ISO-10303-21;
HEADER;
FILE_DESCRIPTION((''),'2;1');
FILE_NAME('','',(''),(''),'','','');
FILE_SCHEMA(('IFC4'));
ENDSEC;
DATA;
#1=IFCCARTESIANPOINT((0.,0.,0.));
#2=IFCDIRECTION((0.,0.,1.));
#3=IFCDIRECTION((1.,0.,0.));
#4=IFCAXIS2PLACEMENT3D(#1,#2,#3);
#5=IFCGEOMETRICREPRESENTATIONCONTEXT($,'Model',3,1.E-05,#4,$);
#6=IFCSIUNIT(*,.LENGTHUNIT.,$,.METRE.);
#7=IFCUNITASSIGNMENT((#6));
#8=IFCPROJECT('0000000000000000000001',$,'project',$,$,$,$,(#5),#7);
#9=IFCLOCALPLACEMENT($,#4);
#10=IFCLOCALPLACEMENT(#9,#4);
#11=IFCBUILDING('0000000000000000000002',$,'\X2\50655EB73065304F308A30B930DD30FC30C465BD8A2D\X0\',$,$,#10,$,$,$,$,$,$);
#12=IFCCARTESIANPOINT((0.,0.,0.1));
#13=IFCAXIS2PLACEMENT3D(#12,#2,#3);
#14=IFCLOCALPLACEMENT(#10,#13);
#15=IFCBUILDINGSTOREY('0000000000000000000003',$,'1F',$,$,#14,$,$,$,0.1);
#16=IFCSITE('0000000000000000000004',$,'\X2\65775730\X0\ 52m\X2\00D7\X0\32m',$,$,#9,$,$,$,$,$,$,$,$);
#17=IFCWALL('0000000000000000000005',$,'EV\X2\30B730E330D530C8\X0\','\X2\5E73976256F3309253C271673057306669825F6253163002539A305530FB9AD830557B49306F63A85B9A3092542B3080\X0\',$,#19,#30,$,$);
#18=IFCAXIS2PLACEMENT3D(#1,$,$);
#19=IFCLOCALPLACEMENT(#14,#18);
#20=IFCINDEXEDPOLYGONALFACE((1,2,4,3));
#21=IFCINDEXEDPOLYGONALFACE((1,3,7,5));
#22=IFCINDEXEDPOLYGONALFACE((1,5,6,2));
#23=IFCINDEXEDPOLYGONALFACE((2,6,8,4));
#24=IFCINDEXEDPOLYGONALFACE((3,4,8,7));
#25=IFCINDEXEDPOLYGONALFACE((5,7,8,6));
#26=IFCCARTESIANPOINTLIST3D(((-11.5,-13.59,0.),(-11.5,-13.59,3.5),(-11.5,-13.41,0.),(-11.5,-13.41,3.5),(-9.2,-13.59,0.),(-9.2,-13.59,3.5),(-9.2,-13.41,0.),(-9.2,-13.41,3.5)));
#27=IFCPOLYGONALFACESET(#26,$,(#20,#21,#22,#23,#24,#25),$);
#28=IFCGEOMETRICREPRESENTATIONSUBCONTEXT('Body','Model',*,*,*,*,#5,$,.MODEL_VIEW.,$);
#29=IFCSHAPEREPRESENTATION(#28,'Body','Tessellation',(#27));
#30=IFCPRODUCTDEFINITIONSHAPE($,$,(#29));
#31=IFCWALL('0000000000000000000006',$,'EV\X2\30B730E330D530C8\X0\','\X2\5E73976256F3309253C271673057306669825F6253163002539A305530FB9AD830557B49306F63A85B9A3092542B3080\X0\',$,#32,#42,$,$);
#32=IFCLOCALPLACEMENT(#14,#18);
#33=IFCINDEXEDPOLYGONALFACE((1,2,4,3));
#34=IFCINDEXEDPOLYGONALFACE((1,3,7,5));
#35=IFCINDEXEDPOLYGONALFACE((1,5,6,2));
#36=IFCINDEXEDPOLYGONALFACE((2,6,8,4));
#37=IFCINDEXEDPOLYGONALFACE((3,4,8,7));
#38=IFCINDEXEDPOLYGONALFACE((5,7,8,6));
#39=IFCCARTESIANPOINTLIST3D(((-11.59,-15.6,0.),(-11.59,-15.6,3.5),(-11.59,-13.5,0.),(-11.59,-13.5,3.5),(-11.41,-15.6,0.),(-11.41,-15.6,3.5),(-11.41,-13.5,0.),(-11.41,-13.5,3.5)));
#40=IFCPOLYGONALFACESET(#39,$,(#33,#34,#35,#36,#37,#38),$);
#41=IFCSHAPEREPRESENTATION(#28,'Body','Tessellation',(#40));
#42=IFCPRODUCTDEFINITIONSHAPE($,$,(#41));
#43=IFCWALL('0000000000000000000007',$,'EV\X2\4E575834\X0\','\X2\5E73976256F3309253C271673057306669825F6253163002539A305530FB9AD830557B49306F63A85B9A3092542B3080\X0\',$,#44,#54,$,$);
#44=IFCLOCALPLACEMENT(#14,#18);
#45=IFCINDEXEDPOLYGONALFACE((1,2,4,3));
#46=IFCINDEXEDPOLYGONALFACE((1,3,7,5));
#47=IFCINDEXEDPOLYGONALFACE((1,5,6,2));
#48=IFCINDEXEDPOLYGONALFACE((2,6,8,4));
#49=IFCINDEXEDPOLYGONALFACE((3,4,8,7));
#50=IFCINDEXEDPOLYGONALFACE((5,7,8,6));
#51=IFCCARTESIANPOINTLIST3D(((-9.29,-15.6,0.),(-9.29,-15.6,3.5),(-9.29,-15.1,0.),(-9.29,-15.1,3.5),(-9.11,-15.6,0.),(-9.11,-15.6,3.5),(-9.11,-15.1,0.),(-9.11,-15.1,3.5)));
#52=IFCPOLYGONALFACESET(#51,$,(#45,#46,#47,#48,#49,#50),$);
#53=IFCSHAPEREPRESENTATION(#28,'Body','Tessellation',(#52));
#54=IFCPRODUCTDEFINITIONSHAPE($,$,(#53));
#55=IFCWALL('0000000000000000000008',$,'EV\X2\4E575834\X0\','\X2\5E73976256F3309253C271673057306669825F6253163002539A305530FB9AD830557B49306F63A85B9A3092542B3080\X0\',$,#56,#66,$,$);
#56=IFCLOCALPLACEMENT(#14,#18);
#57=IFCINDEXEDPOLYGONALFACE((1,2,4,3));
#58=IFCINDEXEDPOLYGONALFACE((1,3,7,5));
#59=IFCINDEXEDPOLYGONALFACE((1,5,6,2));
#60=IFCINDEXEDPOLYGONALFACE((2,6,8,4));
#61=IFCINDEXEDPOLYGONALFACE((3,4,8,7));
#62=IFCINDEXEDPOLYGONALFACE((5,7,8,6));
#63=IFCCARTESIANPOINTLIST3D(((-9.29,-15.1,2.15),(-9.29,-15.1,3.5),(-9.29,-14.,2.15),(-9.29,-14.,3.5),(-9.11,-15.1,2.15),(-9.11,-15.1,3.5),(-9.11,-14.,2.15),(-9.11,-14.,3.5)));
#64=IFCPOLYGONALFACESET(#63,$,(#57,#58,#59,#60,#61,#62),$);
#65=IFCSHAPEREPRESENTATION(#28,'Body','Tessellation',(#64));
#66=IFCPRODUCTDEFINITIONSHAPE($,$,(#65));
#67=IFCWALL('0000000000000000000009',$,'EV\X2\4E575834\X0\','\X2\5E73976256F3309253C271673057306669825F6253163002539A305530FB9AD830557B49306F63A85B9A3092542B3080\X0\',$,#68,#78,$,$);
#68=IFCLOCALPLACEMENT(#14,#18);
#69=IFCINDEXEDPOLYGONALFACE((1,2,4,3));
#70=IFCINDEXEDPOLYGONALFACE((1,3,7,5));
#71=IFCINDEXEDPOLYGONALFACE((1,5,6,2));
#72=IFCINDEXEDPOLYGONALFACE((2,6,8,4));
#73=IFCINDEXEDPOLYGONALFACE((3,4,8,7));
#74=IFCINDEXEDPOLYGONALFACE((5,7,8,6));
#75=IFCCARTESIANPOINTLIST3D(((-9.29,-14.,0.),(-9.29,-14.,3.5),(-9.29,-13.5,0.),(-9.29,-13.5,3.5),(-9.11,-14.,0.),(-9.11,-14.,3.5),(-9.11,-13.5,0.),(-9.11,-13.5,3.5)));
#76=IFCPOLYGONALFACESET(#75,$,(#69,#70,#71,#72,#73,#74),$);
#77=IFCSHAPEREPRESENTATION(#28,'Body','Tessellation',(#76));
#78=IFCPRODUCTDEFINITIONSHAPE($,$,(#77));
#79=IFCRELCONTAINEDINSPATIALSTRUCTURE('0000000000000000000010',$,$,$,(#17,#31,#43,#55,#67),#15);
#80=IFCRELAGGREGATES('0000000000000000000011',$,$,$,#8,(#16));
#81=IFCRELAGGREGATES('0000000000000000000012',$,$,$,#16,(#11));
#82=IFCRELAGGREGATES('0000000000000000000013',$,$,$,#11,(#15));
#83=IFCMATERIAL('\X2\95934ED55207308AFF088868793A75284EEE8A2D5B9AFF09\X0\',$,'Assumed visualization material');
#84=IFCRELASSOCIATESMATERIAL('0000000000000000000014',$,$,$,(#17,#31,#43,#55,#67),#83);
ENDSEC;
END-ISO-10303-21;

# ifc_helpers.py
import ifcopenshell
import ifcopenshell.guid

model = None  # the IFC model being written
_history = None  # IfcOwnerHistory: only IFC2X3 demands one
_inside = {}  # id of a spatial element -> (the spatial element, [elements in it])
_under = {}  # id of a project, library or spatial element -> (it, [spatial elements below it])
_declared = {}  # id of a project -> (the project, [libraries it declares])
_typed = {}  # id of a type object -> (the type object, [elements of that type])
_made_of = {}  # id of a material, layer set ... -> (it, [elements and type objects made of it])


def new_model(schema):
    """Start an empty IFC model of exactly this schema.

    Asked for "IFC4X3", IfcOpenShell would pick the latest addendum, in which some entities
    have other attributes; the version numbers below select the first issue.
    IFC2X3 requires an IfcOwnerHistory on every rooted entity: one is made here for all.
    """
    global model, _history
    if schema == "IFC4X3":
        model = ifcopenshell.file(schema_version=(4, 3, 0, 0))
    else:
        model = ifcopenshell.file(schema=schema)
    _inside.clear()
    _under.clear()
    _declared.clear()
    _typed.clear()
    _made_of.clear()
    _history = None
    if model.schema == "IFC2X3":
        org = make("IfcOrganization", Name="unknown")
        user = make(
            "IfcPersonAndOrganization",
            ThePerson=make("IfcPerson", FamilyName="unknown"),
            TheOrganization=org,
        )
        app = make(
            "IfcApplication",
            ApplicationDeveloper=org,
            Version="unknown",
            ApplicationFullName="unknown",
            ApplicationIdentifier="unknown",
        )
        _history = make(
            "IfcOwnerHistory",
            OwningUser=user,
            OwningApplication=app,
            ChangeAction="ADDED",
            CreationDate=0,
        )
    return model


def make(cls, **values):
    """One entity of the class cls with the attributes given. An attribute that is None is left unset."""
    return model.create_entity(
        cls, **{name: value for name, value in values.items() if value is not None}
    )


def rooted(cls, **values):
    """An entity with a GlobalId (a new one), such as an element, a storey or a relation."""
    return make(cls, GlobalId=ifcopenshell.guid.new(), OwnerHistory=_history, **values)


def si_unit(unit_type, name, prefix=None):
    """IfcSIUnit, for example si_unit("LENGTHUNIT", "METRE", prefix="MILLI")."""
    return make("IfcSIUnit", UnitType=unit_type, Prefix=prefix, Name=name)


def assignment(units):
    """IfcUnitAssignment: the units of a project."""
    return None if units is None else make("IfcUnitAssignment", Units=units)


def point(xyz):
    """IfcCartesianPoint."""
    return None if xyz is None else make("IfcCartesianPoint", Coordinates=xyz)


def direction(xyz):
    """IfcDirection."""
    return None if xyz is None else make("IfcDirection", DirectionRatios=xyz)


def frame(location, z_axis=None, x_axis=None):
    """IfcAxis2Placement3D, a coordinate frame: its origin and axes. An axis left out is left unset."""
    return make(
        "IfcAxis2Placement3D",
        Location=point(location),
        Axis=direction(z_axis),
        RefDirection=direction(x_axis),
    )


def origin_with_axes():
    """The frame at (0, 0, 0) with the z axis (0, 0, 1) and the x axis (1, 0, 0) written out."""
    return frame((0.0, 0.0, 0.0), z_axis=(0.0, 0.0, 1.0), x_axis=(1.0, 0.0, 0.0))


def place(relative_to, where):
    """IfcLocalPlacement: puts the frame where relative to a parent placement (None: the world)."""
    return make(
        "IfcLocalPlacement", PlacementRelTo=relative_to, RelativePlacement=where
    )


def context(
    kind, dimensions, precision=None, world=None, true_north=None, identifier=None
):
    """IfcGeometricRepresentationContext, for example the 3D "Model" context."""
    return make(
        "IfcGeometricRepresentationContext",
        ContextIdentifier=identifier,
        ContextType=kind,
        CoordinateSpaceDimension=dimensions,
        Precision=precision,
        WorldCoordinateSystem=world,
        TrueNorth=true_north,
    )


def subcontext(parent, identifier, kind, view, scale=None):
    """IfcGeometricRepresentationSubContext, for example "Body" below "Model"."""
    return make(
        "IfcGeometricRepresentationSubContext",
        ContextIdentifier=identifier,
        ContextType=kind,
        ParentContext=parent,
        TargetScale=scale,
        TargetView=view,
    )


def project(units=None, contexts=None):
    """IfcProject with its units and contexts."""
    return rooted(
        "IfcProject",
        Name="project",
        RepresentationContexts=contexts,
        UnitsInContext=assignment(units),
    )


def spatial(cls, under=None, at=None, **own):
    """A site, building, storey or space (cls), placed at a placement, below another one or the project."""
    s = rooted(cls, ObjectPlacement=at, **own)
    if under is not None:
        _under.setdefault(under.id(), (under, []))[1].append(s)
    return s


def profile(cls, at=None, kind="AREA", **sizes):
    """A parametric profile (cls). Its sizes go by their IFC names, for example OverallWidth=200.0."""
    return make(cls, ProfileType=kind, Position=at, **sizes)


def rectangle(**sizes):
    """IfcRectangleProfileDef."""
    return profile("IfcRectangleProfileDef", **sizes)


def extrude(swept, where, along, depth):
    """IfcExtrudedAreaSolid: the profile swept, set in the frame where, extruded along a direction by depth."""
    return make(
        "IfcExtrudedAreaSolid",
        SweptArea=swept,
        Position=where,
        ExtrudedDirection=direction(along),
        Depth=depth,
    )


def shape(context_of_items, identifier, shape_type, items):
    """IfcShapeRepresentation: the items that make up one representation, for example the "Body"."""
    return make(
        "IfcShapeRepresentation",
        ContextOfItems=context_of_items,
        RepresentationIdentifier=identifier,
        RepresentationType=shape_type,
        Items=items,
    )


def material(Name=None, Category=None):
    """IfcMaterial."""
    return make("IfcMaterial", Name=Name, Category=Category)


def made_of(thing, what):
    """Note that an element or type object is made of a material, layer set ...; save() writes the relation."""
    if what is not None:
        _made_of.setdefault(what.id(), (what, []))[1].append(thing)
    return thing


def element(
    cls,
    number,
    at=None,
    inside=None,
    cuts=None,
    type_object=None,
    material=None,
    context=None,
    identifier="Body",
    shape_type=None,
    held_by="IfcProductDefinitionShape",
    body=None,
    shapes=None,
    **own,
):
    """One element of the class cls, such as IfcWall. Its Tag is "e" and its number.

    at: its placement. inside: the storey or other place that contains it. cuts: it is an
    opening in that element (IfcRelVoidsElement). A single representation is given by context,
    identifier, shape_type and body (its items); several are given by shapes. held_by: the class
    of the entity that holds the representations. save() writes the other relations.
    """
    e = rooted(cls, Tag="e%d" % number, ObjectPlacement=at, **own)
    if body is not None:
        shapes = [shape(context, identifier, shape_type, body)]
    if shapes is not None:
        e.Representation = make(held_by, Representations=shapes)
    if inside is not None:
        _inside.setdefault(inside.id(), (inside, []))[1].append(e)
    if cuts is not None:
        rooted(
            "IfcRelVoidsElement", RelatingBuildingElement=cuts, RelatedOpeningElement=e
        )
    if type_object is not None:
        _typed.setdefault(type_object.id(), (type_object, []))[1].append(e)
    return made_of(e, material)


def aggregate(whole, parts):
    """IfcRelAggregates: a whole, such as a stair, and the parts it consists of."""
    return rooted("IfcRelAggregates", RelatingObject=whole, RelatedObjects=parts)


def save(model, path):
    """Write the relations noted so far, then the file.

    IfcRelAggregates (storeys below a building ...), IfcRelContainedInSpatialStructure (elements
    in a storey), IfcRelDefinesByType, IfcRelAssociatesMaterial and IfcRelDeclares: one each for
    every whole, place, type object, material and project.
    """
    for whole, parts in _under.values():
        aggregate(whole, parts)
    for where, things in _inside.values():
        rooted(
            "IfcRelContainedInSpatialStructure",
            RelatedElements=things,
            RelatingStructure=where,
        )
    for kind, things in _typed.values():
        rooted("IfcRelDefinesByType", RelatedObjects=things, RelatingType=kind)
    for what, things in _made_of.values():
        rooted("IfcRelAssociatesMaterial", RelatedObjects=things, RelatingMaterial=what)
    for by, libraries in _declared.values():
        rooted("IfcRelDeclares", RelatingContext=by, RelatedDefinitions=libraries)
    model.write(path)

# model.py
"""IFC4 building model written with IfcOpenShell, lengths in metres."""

from ifc_helpers import new_model, si_unit, frame, origin_with_axes, place, context, subcontext, project, spatial, rectangle, extrude, material, element, save


model = new_model("IFC4")

# Units and contexts
model_context = context("Model", 3, precision=1e-05, world=origin_with_axes())
body_context = subcontext(model_context, "Body", "Model", "MODEL_VIEW")
ifc_project = project(units=[si_unit("LENGTHUNIT", "METRE")], contexts=[model_context])

# Site, building, storey
site_placement = place(None, origin_with_axes())
site = spatial("IfcSite", under=ifc_project, at=site_placement, Name="敷地 52m×32m")
building_placement = place(site_placement, origin_with_axes())
building = spatial("IfcBuilding", under=site, at=building_placement, Name="健康づくりスポーツ施設")
storey_placement = place(building_placement, frame((0.0, 0.0, 0.1), z_axis=(0.0, 0.0, 1.0), x_axis=(1.0, 0.0, 0.0)))
storey = spatial("IfcBuildingStorey", under=building, at=storey_placement, Name="1F", Elevation=0.1)

# Walls
ifc_material_1 = material(Name="間仕切り（表示用仮設定）", Category="Assumed visualization material")
for number, where, z_axis, x_axis, name in (
    (1, (-10.35, -13.5, 0.0), (0.0, 0.0, 1.0), (1.0, 0.0, 0.0), "EVシャフト"),
):
    element("IfcWall", number, at=place(storey_placement, frame(where, z_axis=z_axis, x_axis=x_axis)), inside=storey, material=ifc_material_1, Name=name, Description="平面図を参照して概形化。厚さ・高さ等は推定を含む", context=body_context, shape_type="SweptSolid", body=[
        extrude(rectangle(XDim=2.3, YDim=0.18), origin_with_axes(), (0.0, 0.0, 1.0), 3.5),
    ])
wall_1_placement = place(storey_placement, frame((-11.5, -14.55, 0.0), z_axis=(0.0, 0.0, 1.0), x_axis=(1.0, 0.0, 0.0)))
element("IfcWall", 2, at=wall_1_placement, inside=storey, material=ifc_material_1, Name="EVシャフト", Description="平面図を参照して概形化。厚さ・高さ等は推定を含む", context=body_context, shape_type="SweptSolid", body=[
    extrude(rectangle(XDim=0.18, YDim=2.1), origin_with_axes(), (0.0, 0.0, 1.0), 3.5),
])
wall_2_placement = place(storey_placement, frame((-9.2, -15.35, 0.0), z_axis=(0.0, 0.0, 1.0), x_axis=(1.0, 0.0, 0.0)))
element("IfcWall", 3, at=wall_2_placement, inside=storey, material=ifc_material_1, Name="EV乗場", Description="平面図を参照して概形化。厚さ・高さ等は推定を含む", context=body_context, shape_type="SweptSolid", body=[
    extrude(rectangle(XDim=0.18, YDim=0.5), origin_with_axes(), (0.0, 0.0, 1.0), 3.5),
])
wall_3_placement = place(storey_placement, frame((-9.2, -14.55, 2.15), z_axis=(0.0, 0.0, 1.0), x_axis=(1.0, 0.0, 0.0)))
element("IfcWall", 4, at=wall_3_placement, inside=storey, material=ifc_material_1, Name="EV乗場", Description="平面図を参照して概形化。厚さ・高さ等は推定を含む", context=body_context, shape_type="SweptSolid", body=[
    extrude(rectangle(XDim=0.18, YDim=1.1), origin_with_axes(), (0.0, 0.0, 1.0), 1.35),
])
wall_4_placement = place(storey_placement, frame((-9.2, -13.75, 0.0), z_axis=(0.0, 0.0, 1.0), x_axis=(1.0, 0.0, 0.0)))
element("IfcWall", 5, at=wall_4_placement, inside=storey, material=ifc_material_1, Name="EV乗場", Description="平面図を参照して概形化。厚さ・高さ等は推定を含む", context=body_context, shape_type="SweptSolid", body=[
    extrude(rectangle(XDim=0.18, YDim=0.5), origin_with_axes(), (0.0, 0.0, 1.0), 3.5),
])

save(model, "model.ifc")
